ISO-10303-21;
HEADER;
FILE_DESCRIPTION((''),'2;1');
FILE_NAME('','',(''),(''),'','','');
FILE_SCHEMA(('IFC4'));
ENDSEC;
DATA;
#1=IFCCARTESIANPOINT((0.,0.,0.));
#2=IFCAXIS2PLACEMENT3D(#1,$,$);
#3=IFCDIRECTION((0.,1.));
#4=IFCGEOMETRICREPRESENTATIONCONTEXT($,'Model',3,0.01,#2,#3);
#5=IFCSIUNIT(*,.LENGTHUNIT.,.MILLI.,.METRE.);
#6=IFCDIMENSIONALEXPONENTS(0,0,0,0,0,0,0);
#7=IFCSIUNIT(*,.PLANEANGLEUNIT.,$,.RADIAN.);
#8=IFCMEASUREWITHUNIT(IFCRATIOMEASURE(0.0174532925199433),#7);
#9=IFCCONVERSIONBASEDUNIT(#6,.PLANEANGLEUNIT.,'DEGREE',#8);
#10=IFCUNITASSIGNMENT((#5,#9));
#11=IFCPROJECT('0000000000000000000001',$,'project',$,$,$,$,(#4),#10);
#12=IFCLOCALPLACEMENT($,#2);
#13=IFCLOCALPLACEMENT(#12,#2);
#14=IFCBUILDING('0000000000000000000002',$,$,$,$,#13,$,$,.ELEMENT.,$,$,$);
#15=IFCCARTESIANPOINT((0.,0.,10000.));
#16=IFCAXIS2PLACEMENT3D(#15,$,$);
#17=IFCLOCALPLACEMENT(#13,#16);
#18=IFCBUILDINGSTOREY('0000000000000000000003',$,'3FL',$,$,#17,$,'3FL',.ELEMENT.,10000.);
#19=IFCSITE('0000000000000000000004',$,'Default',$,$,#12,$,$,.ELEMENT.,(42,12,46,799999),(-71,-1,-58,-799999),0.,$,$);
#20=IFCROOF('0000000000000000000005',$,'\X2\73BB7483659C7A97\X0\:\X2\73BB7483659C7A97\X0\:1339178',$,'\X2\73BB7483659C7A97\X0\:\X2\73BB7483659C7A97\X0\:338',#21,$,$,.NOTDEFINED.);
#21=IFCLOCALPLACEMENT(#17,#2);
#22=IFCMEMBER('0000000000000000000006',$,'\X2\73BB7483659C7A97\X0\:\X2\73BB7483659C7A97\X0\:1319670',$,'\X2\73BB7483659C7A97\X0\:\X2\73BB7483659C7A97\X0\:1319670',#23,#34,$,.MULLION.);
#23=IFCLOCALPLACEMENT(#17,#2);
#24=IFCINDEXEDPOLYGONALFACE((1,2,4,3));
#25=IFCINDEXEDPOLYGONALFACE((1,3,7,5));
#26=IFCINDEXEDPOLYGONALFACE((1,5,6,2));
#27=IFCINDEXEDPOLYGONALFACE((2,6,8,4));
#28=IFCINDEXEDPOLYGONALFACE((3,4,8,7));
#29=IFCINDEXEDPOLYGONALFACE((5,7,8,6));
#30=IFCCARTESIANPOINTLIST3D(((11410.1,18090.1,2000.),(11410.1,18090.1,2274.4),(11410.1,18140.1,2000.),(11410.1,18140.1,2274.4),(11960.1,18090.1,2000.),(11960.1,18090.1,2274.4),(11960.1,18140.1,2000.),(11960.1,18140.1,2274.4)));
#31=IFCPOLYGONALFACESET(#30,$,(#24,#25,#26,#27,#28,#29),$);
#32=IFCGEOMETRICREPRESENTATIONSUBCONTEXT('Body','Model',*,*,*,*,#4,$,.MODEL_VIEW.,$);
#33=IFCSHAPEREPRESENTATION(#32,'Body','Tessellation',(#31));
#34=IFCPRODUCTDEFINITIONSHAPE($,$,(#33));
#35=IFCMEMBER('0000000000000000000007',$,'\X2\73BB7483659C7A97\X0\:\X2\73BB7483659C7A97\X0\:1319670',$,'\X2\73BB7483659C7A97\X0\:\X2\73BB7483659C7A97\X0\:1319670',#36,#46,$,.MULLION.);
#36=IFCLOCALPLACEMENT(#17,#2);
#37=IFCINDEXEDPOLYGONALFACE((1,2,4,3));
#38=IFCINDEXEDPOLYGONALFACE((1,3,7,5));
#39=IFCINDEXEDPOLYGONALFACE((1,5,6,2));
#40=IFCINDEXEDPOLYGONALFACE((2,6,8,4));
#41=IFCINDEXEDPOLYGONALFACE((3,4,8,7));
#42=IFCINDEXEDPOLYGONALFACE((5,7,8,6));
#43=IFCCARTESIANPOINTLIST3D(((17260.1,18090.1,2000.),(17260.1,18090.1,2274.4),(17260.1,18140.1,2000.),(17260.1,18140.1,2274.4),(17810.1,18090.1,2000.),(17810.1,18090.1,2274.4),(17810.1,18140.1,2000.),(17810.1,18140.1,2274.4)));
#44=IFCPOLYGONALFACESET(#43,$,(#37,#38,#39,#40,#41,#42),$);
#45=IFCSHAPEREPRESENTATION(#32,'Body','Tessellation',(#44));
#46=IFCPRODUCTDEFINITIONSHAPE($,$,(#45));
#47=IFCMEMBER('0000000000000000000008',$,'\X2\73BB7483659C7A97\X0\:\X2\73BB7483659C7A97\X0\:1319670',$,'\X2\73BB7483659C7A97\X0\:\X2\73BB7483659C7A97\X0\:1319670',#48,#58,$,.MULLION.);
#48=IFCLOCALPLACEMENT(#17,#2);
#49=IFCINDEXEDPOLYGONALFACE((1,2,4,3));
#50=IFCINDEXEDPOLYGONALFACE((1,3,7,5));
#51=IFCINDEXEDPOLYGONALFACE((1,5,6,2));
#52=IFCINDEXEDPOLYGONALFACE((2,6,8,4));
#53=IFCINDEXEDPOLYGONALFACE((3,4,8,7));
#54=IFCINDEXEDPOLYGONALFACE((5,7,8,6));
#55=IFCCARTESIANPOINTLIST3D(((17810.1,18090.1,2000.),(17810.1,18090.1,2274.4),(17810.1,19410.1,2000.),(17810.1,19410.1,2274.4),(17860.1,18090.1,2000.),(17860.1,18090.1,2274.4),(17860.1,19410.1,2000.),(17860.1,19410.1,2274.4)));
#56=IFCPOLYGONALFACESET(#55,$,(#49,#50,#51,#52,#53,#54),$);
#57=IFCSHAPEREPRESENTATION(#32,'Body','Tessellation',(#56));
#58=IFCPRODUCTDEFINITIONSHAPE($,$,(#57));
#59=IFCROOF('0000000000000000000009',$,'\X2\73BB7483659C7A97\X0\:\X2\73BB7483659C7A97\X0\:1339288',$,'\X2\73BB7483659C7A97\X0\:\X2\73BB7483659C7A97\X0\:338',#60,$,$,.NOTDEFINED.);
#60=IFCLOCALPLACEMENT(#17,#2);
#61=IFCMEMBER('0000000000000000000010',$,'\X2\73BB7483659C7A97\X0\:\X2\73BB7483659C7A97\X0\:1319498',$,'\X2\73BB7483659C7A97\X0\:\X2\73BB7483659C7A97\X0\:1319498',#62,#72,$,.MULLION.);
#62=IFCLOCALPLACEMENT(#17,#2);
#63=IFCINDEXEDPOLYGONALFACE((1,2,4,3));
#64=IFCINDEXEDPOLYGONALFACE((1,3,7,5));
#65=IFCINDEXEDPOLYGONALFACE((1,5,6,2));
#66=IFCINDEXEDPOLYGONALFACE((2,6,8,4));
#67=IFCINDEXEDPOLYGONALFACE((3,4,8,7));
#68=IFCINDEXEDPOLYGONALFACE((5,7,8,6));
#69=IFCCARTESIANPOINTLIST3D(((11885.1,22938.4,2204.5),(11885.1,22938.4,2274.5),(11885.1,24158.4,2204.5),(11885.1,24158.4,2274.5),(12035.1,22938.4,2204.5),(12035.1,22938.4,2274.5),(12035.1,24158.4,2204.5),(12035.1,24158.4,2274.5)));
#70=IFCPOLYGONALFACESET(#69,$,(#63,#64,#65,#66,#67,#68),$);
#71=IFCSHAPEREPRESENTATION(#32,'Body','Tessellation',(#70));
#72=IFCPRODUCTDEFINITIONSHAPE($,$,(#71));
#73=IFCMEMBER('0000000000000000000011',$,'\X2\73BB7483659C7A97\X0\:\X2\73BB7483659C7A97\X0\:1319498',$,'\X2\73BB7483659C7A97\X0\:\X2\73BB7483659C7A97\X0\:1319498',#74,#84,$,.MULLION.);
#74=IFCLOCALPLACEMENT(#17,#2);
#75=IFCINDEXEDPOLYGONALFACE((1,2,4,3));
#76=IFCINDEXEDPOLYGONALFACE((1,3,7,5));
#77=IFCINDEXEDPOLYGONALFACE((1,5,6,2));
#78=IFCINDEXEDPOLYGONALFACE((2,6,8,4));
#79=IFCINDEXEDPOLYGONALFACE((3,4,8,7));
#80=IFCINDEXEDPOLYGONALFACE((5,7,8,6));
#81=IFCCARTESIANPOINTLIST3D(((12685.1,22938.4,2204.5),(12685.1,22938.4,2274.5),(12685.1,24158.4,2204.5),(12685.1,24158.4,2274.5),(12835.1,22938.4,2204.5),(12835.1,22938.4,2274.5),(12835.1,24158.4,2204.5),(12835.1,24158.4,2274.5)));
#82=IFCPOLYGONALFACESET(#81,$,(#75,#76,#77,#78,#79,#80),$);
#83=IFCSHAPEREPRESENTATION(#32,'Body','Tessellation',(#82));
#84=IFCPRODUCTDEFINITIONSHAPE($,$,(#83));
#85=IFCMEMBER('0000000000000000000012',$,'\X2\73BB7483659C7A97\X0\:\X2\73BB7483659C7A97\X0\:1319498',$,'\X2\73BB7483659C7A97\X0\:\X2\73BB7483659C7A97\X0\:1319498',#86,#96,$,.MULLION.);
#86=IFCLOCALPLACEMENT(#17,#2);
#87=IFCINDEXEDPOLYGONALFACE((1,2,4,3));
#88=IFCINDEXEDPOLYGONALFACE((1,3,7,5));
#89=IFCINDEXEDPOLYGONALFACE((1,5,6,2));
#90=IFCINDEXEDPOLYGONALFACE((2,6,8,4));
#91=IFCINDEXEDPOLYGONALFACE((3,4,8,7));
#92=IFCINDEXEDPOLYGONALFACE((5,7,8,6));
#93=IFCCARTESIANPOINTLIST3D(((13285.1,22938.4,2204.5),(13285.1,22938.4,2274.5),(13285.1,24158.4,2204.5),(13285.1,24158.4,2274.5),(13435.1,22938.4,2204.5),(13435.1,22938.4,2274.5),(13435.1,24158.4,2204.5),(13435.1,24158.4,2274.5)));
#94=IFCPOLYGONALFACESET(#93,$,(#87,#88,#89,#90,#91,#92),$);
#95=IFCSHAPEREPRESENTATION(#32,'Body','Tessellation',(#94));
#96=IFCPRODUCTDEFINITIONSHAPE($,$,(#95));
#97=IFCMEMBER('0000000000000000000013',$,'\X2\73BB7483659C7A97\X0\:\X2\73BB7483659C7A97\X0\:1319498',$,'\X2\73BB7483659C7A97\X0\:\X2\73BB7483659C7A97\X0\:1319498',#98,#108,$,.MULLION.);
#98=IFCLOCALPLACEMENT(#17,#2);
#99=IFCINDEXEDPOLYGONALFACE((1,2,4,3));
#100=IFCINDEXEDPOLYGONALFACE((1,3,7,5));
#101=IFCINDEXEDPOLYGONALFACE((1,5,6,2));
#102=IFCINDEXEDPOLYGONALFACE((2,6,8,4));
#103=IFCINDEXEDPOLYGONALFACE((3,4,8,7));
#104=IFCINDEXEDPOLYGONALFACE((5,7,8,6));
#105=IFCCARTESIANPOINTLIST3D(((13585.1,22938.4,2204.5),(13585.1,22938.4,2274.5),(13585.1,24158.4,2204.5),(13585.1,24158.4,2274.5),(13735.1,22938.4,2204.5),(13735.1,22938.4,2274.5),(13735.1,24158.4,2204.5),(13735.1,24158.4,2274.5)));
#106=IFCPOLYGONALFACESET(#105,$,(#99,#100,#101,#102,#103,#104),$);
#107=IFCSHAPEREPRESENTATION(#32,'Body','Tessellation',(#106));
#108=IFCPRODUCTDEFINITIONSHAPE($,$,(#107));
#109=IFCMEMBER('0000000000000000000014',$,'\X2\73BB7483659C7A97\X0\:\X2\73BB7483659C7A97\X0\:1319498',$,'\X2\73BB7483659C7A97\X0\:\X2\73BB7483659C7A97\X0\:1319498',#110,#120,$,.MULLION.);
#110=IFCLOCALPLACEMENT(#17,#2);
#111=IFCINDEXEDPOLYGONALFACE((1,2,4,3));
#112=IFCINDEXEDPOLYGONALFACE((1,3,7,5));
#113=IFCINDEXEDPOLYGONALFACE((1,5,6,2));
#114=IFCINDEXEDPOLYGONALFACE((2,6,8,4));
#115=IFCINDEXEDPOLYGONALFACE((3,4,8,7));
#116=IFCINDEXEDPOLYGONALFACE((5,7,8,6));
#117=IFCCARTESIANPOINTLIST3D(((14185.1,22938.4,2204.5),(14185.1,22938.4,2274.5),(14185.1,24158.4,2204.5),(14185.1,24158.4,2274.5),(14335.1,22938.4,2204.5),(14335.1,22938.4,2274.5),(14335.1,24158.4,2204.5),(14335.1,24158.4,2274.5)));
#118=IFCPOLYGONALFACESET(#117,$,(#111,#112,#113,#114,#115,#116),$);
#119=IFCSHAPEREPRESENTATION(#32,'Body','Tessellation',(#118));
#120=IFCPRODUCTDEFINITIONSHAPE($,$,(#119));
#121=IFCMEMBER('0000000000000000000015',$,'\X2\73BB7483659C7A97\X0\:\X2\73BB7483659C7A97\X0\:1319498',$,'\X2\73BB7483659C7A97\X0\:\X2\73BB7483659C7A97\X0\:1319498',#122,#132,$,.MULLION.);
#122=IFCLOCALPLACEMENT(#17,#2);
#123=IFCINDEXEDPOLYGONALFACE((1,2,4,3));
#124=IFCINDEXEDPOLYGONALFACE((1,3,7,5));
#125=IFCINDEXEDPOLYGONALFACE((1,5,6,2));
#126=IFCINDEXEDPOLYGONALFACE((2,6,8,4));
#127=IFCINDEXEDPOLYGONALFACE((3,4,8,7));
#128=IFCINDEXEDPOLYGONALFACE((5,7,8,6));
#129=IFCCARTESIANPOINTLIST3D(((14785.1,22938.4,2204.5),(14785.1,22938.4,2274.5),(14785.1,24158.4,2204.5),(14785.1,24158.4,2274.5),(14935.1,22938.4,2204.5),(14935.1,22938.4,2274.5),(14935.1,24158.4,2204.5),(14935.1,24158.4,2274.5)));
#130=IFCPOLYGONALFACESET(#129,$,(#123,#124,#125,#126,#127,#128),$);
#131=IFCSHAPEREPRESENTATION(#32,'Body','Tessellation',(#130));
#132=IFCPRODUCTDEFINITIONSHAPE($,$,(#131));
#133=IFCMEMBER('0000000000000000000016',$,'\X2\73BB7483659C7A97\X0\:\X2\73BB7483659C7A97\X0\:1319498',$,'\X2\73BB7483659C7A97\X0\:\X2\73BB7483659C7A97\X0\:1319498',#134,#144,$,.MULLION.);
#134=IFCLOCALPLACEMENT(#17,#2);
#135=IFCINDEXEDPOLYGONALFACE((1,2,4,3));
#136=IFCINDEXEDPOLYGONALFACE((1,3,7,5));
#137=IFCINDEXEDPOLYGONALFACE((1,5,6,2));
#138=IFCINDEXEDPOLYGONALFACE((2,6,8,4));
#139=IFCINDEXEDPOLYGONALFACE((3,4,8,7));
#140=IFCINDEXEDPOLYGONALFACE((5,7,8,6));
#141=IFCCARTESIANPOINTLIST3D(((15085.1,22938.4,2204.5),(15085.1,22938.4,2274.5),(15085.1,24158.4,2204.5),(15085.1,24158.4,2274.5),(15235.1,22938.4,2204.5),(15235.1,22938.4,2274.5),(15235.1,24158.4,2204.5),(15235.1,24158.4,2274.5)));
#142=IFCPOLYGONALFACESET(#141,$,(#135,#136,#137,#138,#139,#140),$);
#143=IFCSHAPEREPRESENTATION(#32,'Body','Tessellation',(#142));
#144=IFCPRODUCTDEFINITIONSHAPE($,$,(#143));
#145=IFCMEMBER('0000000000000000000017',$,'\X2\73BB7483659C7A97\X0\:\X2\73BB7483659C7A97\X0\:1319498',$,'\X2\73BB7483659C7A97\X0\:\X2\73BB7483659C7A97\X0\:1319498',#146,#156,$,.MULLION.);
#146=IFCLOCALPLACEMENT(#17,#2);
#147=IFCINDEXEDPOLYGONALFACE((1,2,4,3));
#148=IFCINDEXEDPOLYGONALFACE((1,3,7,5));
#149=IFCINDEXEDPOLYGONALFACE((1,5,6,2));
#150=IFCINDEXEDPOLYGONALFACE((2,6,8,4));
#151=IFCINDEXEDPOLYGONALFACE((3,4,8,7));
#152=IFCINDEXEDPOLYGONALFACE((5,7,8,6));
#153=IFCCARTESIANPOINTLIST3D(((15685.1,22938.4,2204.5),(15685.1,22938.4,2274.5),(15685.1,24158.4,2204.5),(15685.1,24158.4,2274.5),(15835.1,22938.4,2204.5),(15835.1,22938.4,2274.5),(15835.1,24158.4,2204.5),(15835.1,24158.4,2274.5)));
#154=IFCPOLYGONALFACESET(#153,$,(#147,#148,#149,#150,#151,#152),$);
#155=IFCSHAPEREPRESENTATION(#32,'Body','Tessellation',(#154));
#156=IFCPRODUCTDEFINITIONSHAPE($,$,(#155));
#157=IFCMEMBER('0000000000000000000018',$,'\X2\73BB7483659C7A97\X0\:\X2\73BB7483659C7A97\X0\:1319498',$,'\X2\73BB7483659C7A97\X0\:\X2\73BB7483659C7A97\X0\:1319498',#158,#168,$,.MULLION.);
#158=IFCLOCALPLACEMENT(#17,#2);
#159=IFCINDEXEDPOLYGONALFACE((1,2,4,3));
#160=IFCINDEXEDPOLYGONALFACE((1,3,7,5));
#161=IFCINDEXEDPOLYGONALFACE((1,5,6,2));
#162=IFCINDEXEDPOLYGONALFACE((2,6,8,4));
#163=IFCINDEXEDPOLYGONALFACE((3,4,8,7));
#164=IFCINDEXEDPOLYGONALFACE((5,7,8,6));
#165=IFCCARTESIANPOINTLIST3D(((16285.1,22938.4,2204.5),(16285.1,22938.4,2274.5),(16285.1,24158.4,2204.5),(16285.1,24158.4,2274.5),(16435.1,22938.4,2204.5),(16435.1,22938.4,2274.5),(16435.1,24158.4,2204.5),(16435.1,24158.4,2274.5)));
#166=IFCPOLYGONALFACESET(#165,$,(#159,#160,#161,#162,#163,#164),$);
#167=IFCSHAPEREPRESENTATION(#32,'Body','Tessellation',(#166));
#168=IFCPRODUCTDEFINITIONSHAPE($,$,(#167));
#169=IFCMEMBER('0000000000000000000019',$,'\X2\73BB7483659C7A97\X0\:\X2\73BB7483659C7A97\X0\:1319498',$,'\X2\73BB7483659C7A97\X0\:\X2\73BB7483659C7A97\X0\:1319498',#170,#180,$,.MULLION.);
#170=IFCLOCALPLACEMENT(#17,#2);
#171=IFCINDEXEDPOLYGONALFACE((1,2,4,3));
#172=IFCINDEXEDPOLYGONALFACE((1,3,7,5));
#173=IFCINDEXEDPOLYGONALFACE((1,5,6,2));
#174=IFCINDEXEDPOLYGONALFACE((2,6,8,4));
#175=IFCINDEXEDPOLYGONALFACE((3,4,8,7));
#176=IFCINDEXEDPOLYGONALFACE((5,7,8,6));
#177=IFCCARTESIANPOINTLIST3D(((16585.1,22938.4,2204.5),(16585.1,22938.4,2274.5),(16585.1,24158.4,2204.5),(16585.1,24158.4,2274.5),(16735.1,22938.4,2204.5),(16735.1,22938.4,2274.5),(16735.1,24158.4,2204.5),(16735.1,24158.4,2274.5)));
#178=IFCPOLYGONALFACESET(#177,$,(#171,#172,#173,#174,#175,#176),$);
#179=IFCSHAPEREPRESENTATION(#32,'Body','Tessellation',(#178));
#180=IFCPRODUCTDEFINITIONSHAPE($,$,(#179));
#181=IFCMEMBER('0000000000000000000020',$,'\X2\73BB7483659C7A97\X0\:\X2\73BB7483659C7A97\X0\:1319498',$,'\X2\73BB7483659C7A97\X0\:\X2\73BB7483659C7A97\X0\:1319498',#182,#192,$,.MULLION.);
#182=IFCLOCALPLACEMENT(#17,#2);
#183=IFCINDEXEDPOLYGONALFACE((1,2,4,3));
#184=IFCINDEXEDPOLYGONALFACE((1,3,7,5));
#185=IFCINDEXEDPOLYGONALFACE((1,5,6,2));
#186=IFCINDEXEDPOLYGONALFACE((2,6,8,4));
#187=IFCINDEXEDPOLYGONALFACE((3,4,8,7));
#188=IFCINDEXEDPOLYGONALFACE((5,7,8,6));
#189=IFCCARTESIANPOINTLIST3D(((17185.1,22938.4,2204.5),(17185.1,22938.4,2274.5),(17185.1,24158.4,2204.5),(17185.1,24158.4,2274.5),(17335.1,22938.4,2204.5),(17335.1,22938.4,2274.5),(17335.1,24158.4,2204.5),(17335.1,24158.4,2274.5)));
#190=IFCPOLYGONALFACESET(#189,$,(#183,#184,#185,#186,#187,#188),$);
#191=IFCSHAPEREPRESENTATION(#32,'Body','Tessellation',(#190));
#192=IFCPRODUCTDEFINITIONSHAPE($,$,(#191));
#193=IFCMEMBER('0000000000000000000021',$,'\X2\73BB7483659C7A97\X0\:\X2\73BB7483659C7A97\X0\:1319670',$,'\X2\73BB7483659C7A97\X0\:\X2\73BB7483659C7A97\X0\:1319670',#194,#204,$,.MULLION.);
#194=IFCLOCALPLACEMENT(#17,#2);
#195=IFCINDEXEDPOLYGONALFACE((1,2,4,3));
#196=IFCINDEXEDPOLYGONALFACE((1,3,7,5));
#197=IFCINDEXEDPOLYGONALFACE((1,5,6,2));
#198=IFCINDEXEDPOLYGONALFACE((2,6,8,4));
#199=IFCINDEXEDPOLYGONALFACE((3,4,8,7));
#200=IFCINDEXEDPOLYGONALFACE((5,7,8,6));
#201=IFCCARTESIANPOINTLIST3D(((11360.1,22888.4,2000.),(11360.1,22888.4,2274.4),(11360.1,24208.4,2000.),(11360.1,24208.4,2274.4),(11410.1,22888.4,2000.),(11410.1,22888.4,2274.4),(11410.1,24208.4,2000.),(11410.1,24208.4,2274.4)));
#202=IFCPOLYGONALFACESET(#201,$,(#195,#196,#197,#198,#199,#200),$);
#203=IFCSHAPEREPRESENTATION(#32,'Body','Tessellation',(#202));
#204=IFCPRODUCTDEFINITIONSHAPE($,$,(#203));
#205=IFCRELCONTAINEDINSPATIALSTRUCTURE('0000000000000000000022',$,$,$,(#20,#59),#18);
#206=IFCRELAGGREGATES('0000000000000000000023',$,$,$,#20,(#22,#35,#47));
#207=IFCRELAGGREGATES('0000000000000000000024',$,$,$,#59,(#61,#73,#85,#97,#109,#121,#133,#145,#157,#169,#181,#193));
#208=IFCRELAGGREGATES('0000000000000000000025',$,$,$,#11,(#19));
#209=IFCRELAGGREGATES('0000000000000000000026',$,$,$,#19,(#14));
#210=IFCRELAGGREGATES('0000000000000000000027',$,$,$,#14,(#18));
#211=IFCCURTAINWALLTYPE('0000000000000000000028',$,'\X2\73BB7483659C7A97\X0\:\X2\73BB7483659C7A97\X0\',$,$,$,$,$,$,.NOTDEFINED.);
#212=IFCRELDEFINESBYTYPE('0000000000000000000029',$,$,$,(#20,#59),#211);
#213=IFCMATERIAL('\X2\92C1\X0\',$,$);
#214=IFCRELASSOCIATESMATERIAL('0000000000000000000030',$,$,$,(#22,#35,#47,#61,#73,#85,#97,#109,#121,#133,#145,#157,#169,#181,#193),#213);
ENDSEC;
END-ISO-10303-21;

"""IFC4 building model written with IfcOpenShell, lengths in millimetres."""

from ifc_helpers import new_model, entity, si_unit, converted_unit, direction, frame, frame_2d, origin, place, context, subcontext, project, spatial, rectangle, extrude, material, type_object, element, aggregate, save


model = new_model("IFC4")

# Units and contexts
model_context = context("Model", 3, precision=0.01, world=origin(), true_north=direction((0.0, 1.0)))
body_context = subcontext(model_context, "Body", "Model", "MODEL_VIEW")
ifc_project = project(units=[si_unit("LENGTHUNIT", "METRE", prefix="MILLI"), converted_unit("PLANEANGLEUNIT", "DEGREE", entity("IfcRatioMeasure", 0.0174532925199433), si_unit("PLANEANGLEUNIT", "RADIAN"), dimensions=[0, 0, 0, 0, 0, 0, 0])], contexts=[model_context])

# Site, building, storey
site_placement = place(None, origin())
site = spatial("IfcSite", under=ifc_project, at=site_placement, Name="Default", CompositionType="ELEMENT", RefLatitude=(42, 12, 46, 799999), RefLongitude=(-71, -1, -58, -799999), RefElevation=0.0)
building_placement = place(site_placement, origin())
building = spatial("IfcBuilding", under=site, at=building_placement, CompositionType="ELEMENT")
storey_placement = place(building_placement, frame((0.0, 0.0, 10000.0)))
storey = spatial("IfcBuildingStorey", under=building, at=storey_placement, Name="3FL", LongName="3FL", CompositionType="ELEMENT", Elevation=10000.0)

# Roofs, members
curtain_wall_type = type_object("IfcCurtainWallType", Name="玻璃斜窗:玻璃斜窗", PredefinedType="NOTDEFINED")
roof_1_placement = place(storey_placement, frame((0.0, 0.0, -10000.0)))
roof_1 = element("IfcRoof", 1, at=roof_1_placement, inside=storey, type_object=curtain_wall_type, Name="玻璃斜窗:玻璃斜窗:1339178", ObjectType="玻璃斜窗:玻璃斜窗:338", PredefinedType="NOTDEFINED")
ifc_material = material(Name="鋁")
member_1_placement = place(roof_1_placement, frame((0.0, 0.0, 10000.0)))
member_1 = element("IfcMember", 2, at=member_1_placement, material=ifc_material, Name="玻璃斜窗:玻璃斜窗:1319670", ObjectType="玻璃斜窗:玻璃斜窗:1319670", PredefinedType="MULLION", context=body_context, shape_type="SweptSolid", body=[
    extrude(rectangle(XDim=274.5, YDim=50.0, at=frame_2d((0.0, 0.0), x_axis=(1.0, 0.0))), frame((11960.1, 18115.1, 2137.2), z_axis=(-1.0, 0.0, 0.0), x_axis=(0.0, 0.0, -1.0)), (0.0, 0.0, 1.0), 550.0),
])
member_2_placement = place(roof_1_placement, frame((0.0, 0.0, 10000.0)))
member_2 = element("IfcMember", 3, at=member_2_placement, material=ifc_material, Name="玻璃斜窗:玻璃斜窗:1319670", ObjectType="玻璃斜窗:玻璃斜窗:1319670", PredefinedType="MULLION", context=body_context, shape_type="SweptSolid", body=[
    extrude(rectangle(XDim=274.5, YDim=50.0, at=frame_2d((0.0, 0.0), x_axis=(1.0, 0.0))), frame((17810.1, 18115.1, 2137.2), z_axis=(-1.0, 0.0, 0.0), x_axis=(0.0, 0.0, -1.0)), (0.0, 0.0, 1.0), 550.0),
])
member_3_placement = place(roof_1_placement, frame((0.0, 0.0, 10000.0)))
member_3 = element("IfcMember", 4, at=member_3_placement, material=ifc_material, Name="玻璃斜窗:玻璃斜窗:1319670", ObjectType="玻璃斜窗:玻璃斜窗:1319670", PredefinedType="MULLION", context=body_context, shape_type="SweptSolid", body=[
    extrude(rectangle(XDim=274.5, YDim=50.0, at=frame_2d((0.0, 0.0), x_axis=(1.0, 0.0))), frame((17835.1, 19410.1, 2137.2), z_axis=(0.0, -1.0, 0.0), x_axis=(0.0, 0.0, -1.0)), (0.0, 0.0, 1.0), 1320.0),
])
aggregate(roof_1, [member_1, member_2, member_3])
roof_2_placement = place(storey_placement, frame((0.0, 0.0, -10000.0)))
roof_2 = element("IfcRoof", 5, at=roof_2_placement, inside=storey, type_object=curtain_wall_type, Name="玻璃斜窗:玻璃斜窗:1339288", ObjectType="玻璃斜窗:玻璃斜窗:338", PredefinedType="NOTDEFINED")
member_4_placement = place(roof_2_placement, frame((0.0, 0.0, 10000.0)))
member_4 = element("IfcMember", 6, at=member_4_placement, material=ifc_material, Name="玻璃斜窗:玻璃斜窗:1319498", ObjectType="玻璃斜窗:玻璃斜窗:1319498", PredefinedType="MULLION", context=body_context, shape_type="SweptSolid", body=[
    extrude(rectangle(XDim=70.0, YDim=150.0, at=frame_2d((0.0, 0.0), x_axis=(1.0, 0.0))), frame((11960.1, 22938.4, 2239.5), z_axis=(0.0, 1.0, 0.0), x_axis=(0.0, 0.0, -1.0)), (0.0, 0.0, 1.0), 1220.0),
])
member_5_placement = place(roof_2_placement, frame((0.0, 0.0, 10000.0)))
member_5 = element("IfcMember", 7, at=member_5_placement, material=ifc_material, Name="玻璃斜窗:玻璃斜窗:1319498", ObjectType="玻璃斜窗:玻璃斜窗:1319498", PredefinedType="MULLION", context=body_context, shape_type="SweptSolid", body=[
    extrude(rectangle(XDim=70.0, YDim=150.0, at=frame_2d((0.0, 0.0), x_axis=(1.0, 0.0))), frame((12760.1, 22938.4, 2239.5), z_axis=(0.0, 1.0, 0.0), x_axis=(0.0, 0.0, -1.0)), (0.0, 0.0, 1.0), 1220.0),
])
member_6_placement = place(roof_2_placement, frame((0.0, 0.0, 10000.0)))
member_6 = element("IfcMember", 8, at=member_6_placement, material=ifc_material, Name="玻璃斜窗:玻璃斜窗:1319498", ObjectType="玻璃斜窗:玻璃斜窗:1319498", PredefinedType="MULLION", context=body_context, shape_type="SweptSolid", body=[
    extrude(rectangle(XDim=70.0, YDim=150.0, at=frame_2d((0.0, 0.0), x_axis=(1.0, 0.0))), frame((13360.1, 22938.4, 2239.5), z_axis=(0.0, 1.0, 0.0), x_axis=(0.0, 0.0, -1.0)), (0.0, 0.0, 1.0), 1220.0),
])
member_7_placement = place(roof_2_placement, frame((0.0, 0.0, 10000.0)))
member_7 = element("IfcMember", 9, at=member_7_placement, material=ifc_material, Name="玻璃斜窗:玻璃斜窗:1319498", ObjectType="玻璃斜窗:玻璃斜窗:1319498", PredefinedType="MULLION", context=body_context, shape_type="SweptSolid", body=[
    extrude(rectangle(XDim=70.0, YDim=150.0, at=frame_2d((0.0, 0.0), x_axis=(1.0, 0.0))), frame((13660.1, 22938.4, 2239.5), z_axis=(0.0, 1.0, 0.0), x_axis=(0.0, 0.0, -1.0)), (0.0, 0.0, 1.0), 1220.0),
])
member_8_placement = place(roof_2_placement, frame((0.0, 0.0, 10000.0)))
member_8 = element("IfcMember", 10, at=member_8_placement, material=ifc_material, Name="玻璃斜窗:玻璃斜窗:1319498", ObjectType="玻璃斜窗:玻璃斜窗:1319498", PredefinedType="MULLION", context=body_context, shape_type="SweptSolid", body=[
    extrude(rectangle(XDim=70.0, YDim=150.0, at=frame_2d((0.0, 0.0), x_axis=(1.0, 0.0))), frame((14260.1, 22938.4, 2239.5), z_axis=(0.0, 1.0, 0.0), x_axis=(0.0, 0.0, -1.0)), (0.0, 0.0, 1.0), 1220.0),
])
member_9_placement = place(roof_2_placement, frame((0.0, 0.0, 10000.0)))
member_9 = element("IfcMember", 11, at=member_9_placement, material=ifc_material, Name="玻璃斜窗:玻璃斜窗:1319498", ObjectType="玻璃斜窗:玻璃斜窗:1319498", PredefinedType="MULLION", context=body_context, shape_type="SweptSolid", body=[
    extrude(rectangle(XDim=70.0, YDim=150.0, at=frame_2d((0.0, 0.0), x_axis=(1.0, 0.0))), frame((14860.1, 22938.4, 2239.5), z_axis=(0.0, 1.0, 0.0), x_axis=(0.0, 0.0, -1.0)), (0.0, 0.0, 1.0), 1220.0),
])
member_10_placement = place(roof_2_placement, frame((0.0, 0.0, 10000.0)))
member_10 = element("IfcMember", 12, at=member_10_placement, material=ifc_material, Name="玻璃斜窗:玻璃斜窗:1319498", ObjectType="玻璃斜窗:玻璃斜窗:1319498", PredefinedType="MULLION", context=body_context, shape_type="SweptSolid", body=[
    extrude(rectangle(XDim=70.0, YDim=150.0, at=frame_2d((0.0, 0.0), x_axis=(1.0, 0.0))), frame((15160.1, 22938.4, 2239.5), z_axis=(0.0, 1.0, 0.0), x_axis=(0.0, 0.0, -1.0)), (0.0, 0.0, 1.0), 1220.0),
])
member_11_placement = place(roof_2_placement, frame((0.0, 0.0, 10000.0)))
member_11 = element("IfcMember", 13, at=member_11_placement, material=ifc_material, Name="玻璃斜窗:玻璃斜窗:1319498", ObjectType="玻璃斜窗:玻璃斜窗:1319498", PredefinedType="MULLION", context=body_context, shape_type="SweptSolid", body=[
    extrude(rectangle(XDim=70.0, YDim=150.0, at=frame_2d((0.0, 0.0), x_axis=(1.0, 0.0))), frame((15760.1, 22938.4, 2239.5), z_axis=(0.0, 1.0, 0.0), x_axis=(0.0, 0.0, -1.0)), (0.0, 0.0, 1.0), 1220.0),
])
member_12_placement = place(roof_2_placement, frame((0.0, 0.0, 10000.0)))
member_12 = element("IfcMember", 14, at=member_12_placement, material=ifc_material, Name="玻璃斜窗:玻璃斜窗:1319498", ObjectType="玻璃斜窗:玻璃斜窗:1319498", PredefinedType="MULLION", context=body_context, shape_type="SweptSolid", body=[
    extrude(rectangle(XDim=70.0, YDim=150.0, at=frame_2d((0.0, 0.0), x_axis=(1.0, 0.0))), frame((16360.1, 22938.4, 2239.5), z_axis=(0.0, 1.0, 0.0), x_axis=(0.0, 0.0, -1.0)), (0.0, 0.0, 1.0), 1220.0),
])
member_13_placement = place(roof_2_placement, frame((0.0, 0.0, 10000.0)))
member_13 = element("IfcMember", 15, at=member_13_placement, material=ifc_material, Name="玻璃斜窗:玻璃斜窗:1319498", ObjectType="玻璃斜窗:玻璃斜窗:1319498", PredefinedType="MULLION", context=body_context, shape_type="SweptSolid", body=[
    extrude(rectangle(XDim=70.0, YDim=150.0, at=frame_2d((0.0, 0.0), x_axis=(1.0, 0.0))), frame((16660.1, 22938.4, 2239.5), z_axis=(0.0, 1.0, 0.0), x_axis=(0.0, 0.0, -1.0)), (0.0, 0.0, 1.0), 1220.0),
])
member_14_placement = place(roof_2_placement, frame((0.0, 0.0, 10000.0)))
member_14 = element("IfcMember", 16, at=member_14_placement, material=ifc_material, Name="玻璃斜窗:玻璃斜窗:1319498", ObjectType="玻璃斜窗:玻璃斜窗:1319498", PredefinedType="MULLION", context=body_context, shape_type="SweptSolid", body=[
    extrude(rectangle(XDim=70.0, YDim=150.0, at=frame_2d((0.0, 0.0), x_axis=(1.0, 0.0))), frame((17260.1, 22938.4, 2239.5), z_axis=(0.0, 1.0, 0.0), x_axis=(0.0, 0.0, -1.0)), (0.0, 0.0, 1.0), 1220.0),
])
member_15_placement = place(roof_2_placement, frame((0.0, 0.0, 10000.0)))
member_15 = element("IfcMember", 17, at=member_15_placement, material=ifc_material, Name="玻璃斜窗:玻璃斜窗:1319670", ObjectType="玻璃斜窗:玻璃斜窗:1319670", PredefinedType="MULLION", context=body_context, shape_type="SweptSolid", body=[
    extrude(rectangle(XDim=274.5, YDim=50.0, at=frame_2d((0.0, 0.0), x_axis=(1.0, 0.0))), frame((11385.1, 22888.4, 2137.2), z_axis=(0.0, 1.0, 0.0), x_axis=(0.0, 0.0, -1.0)), (0.0, 0.0, 1.0), 1320.0),
])
aggregate(roof_2, [member_4, member_5, member_6, member_7, member_8, member_9, member_10, member_11, member_12, member_13, member_14, member_15])

save(model, "model.ifc")
